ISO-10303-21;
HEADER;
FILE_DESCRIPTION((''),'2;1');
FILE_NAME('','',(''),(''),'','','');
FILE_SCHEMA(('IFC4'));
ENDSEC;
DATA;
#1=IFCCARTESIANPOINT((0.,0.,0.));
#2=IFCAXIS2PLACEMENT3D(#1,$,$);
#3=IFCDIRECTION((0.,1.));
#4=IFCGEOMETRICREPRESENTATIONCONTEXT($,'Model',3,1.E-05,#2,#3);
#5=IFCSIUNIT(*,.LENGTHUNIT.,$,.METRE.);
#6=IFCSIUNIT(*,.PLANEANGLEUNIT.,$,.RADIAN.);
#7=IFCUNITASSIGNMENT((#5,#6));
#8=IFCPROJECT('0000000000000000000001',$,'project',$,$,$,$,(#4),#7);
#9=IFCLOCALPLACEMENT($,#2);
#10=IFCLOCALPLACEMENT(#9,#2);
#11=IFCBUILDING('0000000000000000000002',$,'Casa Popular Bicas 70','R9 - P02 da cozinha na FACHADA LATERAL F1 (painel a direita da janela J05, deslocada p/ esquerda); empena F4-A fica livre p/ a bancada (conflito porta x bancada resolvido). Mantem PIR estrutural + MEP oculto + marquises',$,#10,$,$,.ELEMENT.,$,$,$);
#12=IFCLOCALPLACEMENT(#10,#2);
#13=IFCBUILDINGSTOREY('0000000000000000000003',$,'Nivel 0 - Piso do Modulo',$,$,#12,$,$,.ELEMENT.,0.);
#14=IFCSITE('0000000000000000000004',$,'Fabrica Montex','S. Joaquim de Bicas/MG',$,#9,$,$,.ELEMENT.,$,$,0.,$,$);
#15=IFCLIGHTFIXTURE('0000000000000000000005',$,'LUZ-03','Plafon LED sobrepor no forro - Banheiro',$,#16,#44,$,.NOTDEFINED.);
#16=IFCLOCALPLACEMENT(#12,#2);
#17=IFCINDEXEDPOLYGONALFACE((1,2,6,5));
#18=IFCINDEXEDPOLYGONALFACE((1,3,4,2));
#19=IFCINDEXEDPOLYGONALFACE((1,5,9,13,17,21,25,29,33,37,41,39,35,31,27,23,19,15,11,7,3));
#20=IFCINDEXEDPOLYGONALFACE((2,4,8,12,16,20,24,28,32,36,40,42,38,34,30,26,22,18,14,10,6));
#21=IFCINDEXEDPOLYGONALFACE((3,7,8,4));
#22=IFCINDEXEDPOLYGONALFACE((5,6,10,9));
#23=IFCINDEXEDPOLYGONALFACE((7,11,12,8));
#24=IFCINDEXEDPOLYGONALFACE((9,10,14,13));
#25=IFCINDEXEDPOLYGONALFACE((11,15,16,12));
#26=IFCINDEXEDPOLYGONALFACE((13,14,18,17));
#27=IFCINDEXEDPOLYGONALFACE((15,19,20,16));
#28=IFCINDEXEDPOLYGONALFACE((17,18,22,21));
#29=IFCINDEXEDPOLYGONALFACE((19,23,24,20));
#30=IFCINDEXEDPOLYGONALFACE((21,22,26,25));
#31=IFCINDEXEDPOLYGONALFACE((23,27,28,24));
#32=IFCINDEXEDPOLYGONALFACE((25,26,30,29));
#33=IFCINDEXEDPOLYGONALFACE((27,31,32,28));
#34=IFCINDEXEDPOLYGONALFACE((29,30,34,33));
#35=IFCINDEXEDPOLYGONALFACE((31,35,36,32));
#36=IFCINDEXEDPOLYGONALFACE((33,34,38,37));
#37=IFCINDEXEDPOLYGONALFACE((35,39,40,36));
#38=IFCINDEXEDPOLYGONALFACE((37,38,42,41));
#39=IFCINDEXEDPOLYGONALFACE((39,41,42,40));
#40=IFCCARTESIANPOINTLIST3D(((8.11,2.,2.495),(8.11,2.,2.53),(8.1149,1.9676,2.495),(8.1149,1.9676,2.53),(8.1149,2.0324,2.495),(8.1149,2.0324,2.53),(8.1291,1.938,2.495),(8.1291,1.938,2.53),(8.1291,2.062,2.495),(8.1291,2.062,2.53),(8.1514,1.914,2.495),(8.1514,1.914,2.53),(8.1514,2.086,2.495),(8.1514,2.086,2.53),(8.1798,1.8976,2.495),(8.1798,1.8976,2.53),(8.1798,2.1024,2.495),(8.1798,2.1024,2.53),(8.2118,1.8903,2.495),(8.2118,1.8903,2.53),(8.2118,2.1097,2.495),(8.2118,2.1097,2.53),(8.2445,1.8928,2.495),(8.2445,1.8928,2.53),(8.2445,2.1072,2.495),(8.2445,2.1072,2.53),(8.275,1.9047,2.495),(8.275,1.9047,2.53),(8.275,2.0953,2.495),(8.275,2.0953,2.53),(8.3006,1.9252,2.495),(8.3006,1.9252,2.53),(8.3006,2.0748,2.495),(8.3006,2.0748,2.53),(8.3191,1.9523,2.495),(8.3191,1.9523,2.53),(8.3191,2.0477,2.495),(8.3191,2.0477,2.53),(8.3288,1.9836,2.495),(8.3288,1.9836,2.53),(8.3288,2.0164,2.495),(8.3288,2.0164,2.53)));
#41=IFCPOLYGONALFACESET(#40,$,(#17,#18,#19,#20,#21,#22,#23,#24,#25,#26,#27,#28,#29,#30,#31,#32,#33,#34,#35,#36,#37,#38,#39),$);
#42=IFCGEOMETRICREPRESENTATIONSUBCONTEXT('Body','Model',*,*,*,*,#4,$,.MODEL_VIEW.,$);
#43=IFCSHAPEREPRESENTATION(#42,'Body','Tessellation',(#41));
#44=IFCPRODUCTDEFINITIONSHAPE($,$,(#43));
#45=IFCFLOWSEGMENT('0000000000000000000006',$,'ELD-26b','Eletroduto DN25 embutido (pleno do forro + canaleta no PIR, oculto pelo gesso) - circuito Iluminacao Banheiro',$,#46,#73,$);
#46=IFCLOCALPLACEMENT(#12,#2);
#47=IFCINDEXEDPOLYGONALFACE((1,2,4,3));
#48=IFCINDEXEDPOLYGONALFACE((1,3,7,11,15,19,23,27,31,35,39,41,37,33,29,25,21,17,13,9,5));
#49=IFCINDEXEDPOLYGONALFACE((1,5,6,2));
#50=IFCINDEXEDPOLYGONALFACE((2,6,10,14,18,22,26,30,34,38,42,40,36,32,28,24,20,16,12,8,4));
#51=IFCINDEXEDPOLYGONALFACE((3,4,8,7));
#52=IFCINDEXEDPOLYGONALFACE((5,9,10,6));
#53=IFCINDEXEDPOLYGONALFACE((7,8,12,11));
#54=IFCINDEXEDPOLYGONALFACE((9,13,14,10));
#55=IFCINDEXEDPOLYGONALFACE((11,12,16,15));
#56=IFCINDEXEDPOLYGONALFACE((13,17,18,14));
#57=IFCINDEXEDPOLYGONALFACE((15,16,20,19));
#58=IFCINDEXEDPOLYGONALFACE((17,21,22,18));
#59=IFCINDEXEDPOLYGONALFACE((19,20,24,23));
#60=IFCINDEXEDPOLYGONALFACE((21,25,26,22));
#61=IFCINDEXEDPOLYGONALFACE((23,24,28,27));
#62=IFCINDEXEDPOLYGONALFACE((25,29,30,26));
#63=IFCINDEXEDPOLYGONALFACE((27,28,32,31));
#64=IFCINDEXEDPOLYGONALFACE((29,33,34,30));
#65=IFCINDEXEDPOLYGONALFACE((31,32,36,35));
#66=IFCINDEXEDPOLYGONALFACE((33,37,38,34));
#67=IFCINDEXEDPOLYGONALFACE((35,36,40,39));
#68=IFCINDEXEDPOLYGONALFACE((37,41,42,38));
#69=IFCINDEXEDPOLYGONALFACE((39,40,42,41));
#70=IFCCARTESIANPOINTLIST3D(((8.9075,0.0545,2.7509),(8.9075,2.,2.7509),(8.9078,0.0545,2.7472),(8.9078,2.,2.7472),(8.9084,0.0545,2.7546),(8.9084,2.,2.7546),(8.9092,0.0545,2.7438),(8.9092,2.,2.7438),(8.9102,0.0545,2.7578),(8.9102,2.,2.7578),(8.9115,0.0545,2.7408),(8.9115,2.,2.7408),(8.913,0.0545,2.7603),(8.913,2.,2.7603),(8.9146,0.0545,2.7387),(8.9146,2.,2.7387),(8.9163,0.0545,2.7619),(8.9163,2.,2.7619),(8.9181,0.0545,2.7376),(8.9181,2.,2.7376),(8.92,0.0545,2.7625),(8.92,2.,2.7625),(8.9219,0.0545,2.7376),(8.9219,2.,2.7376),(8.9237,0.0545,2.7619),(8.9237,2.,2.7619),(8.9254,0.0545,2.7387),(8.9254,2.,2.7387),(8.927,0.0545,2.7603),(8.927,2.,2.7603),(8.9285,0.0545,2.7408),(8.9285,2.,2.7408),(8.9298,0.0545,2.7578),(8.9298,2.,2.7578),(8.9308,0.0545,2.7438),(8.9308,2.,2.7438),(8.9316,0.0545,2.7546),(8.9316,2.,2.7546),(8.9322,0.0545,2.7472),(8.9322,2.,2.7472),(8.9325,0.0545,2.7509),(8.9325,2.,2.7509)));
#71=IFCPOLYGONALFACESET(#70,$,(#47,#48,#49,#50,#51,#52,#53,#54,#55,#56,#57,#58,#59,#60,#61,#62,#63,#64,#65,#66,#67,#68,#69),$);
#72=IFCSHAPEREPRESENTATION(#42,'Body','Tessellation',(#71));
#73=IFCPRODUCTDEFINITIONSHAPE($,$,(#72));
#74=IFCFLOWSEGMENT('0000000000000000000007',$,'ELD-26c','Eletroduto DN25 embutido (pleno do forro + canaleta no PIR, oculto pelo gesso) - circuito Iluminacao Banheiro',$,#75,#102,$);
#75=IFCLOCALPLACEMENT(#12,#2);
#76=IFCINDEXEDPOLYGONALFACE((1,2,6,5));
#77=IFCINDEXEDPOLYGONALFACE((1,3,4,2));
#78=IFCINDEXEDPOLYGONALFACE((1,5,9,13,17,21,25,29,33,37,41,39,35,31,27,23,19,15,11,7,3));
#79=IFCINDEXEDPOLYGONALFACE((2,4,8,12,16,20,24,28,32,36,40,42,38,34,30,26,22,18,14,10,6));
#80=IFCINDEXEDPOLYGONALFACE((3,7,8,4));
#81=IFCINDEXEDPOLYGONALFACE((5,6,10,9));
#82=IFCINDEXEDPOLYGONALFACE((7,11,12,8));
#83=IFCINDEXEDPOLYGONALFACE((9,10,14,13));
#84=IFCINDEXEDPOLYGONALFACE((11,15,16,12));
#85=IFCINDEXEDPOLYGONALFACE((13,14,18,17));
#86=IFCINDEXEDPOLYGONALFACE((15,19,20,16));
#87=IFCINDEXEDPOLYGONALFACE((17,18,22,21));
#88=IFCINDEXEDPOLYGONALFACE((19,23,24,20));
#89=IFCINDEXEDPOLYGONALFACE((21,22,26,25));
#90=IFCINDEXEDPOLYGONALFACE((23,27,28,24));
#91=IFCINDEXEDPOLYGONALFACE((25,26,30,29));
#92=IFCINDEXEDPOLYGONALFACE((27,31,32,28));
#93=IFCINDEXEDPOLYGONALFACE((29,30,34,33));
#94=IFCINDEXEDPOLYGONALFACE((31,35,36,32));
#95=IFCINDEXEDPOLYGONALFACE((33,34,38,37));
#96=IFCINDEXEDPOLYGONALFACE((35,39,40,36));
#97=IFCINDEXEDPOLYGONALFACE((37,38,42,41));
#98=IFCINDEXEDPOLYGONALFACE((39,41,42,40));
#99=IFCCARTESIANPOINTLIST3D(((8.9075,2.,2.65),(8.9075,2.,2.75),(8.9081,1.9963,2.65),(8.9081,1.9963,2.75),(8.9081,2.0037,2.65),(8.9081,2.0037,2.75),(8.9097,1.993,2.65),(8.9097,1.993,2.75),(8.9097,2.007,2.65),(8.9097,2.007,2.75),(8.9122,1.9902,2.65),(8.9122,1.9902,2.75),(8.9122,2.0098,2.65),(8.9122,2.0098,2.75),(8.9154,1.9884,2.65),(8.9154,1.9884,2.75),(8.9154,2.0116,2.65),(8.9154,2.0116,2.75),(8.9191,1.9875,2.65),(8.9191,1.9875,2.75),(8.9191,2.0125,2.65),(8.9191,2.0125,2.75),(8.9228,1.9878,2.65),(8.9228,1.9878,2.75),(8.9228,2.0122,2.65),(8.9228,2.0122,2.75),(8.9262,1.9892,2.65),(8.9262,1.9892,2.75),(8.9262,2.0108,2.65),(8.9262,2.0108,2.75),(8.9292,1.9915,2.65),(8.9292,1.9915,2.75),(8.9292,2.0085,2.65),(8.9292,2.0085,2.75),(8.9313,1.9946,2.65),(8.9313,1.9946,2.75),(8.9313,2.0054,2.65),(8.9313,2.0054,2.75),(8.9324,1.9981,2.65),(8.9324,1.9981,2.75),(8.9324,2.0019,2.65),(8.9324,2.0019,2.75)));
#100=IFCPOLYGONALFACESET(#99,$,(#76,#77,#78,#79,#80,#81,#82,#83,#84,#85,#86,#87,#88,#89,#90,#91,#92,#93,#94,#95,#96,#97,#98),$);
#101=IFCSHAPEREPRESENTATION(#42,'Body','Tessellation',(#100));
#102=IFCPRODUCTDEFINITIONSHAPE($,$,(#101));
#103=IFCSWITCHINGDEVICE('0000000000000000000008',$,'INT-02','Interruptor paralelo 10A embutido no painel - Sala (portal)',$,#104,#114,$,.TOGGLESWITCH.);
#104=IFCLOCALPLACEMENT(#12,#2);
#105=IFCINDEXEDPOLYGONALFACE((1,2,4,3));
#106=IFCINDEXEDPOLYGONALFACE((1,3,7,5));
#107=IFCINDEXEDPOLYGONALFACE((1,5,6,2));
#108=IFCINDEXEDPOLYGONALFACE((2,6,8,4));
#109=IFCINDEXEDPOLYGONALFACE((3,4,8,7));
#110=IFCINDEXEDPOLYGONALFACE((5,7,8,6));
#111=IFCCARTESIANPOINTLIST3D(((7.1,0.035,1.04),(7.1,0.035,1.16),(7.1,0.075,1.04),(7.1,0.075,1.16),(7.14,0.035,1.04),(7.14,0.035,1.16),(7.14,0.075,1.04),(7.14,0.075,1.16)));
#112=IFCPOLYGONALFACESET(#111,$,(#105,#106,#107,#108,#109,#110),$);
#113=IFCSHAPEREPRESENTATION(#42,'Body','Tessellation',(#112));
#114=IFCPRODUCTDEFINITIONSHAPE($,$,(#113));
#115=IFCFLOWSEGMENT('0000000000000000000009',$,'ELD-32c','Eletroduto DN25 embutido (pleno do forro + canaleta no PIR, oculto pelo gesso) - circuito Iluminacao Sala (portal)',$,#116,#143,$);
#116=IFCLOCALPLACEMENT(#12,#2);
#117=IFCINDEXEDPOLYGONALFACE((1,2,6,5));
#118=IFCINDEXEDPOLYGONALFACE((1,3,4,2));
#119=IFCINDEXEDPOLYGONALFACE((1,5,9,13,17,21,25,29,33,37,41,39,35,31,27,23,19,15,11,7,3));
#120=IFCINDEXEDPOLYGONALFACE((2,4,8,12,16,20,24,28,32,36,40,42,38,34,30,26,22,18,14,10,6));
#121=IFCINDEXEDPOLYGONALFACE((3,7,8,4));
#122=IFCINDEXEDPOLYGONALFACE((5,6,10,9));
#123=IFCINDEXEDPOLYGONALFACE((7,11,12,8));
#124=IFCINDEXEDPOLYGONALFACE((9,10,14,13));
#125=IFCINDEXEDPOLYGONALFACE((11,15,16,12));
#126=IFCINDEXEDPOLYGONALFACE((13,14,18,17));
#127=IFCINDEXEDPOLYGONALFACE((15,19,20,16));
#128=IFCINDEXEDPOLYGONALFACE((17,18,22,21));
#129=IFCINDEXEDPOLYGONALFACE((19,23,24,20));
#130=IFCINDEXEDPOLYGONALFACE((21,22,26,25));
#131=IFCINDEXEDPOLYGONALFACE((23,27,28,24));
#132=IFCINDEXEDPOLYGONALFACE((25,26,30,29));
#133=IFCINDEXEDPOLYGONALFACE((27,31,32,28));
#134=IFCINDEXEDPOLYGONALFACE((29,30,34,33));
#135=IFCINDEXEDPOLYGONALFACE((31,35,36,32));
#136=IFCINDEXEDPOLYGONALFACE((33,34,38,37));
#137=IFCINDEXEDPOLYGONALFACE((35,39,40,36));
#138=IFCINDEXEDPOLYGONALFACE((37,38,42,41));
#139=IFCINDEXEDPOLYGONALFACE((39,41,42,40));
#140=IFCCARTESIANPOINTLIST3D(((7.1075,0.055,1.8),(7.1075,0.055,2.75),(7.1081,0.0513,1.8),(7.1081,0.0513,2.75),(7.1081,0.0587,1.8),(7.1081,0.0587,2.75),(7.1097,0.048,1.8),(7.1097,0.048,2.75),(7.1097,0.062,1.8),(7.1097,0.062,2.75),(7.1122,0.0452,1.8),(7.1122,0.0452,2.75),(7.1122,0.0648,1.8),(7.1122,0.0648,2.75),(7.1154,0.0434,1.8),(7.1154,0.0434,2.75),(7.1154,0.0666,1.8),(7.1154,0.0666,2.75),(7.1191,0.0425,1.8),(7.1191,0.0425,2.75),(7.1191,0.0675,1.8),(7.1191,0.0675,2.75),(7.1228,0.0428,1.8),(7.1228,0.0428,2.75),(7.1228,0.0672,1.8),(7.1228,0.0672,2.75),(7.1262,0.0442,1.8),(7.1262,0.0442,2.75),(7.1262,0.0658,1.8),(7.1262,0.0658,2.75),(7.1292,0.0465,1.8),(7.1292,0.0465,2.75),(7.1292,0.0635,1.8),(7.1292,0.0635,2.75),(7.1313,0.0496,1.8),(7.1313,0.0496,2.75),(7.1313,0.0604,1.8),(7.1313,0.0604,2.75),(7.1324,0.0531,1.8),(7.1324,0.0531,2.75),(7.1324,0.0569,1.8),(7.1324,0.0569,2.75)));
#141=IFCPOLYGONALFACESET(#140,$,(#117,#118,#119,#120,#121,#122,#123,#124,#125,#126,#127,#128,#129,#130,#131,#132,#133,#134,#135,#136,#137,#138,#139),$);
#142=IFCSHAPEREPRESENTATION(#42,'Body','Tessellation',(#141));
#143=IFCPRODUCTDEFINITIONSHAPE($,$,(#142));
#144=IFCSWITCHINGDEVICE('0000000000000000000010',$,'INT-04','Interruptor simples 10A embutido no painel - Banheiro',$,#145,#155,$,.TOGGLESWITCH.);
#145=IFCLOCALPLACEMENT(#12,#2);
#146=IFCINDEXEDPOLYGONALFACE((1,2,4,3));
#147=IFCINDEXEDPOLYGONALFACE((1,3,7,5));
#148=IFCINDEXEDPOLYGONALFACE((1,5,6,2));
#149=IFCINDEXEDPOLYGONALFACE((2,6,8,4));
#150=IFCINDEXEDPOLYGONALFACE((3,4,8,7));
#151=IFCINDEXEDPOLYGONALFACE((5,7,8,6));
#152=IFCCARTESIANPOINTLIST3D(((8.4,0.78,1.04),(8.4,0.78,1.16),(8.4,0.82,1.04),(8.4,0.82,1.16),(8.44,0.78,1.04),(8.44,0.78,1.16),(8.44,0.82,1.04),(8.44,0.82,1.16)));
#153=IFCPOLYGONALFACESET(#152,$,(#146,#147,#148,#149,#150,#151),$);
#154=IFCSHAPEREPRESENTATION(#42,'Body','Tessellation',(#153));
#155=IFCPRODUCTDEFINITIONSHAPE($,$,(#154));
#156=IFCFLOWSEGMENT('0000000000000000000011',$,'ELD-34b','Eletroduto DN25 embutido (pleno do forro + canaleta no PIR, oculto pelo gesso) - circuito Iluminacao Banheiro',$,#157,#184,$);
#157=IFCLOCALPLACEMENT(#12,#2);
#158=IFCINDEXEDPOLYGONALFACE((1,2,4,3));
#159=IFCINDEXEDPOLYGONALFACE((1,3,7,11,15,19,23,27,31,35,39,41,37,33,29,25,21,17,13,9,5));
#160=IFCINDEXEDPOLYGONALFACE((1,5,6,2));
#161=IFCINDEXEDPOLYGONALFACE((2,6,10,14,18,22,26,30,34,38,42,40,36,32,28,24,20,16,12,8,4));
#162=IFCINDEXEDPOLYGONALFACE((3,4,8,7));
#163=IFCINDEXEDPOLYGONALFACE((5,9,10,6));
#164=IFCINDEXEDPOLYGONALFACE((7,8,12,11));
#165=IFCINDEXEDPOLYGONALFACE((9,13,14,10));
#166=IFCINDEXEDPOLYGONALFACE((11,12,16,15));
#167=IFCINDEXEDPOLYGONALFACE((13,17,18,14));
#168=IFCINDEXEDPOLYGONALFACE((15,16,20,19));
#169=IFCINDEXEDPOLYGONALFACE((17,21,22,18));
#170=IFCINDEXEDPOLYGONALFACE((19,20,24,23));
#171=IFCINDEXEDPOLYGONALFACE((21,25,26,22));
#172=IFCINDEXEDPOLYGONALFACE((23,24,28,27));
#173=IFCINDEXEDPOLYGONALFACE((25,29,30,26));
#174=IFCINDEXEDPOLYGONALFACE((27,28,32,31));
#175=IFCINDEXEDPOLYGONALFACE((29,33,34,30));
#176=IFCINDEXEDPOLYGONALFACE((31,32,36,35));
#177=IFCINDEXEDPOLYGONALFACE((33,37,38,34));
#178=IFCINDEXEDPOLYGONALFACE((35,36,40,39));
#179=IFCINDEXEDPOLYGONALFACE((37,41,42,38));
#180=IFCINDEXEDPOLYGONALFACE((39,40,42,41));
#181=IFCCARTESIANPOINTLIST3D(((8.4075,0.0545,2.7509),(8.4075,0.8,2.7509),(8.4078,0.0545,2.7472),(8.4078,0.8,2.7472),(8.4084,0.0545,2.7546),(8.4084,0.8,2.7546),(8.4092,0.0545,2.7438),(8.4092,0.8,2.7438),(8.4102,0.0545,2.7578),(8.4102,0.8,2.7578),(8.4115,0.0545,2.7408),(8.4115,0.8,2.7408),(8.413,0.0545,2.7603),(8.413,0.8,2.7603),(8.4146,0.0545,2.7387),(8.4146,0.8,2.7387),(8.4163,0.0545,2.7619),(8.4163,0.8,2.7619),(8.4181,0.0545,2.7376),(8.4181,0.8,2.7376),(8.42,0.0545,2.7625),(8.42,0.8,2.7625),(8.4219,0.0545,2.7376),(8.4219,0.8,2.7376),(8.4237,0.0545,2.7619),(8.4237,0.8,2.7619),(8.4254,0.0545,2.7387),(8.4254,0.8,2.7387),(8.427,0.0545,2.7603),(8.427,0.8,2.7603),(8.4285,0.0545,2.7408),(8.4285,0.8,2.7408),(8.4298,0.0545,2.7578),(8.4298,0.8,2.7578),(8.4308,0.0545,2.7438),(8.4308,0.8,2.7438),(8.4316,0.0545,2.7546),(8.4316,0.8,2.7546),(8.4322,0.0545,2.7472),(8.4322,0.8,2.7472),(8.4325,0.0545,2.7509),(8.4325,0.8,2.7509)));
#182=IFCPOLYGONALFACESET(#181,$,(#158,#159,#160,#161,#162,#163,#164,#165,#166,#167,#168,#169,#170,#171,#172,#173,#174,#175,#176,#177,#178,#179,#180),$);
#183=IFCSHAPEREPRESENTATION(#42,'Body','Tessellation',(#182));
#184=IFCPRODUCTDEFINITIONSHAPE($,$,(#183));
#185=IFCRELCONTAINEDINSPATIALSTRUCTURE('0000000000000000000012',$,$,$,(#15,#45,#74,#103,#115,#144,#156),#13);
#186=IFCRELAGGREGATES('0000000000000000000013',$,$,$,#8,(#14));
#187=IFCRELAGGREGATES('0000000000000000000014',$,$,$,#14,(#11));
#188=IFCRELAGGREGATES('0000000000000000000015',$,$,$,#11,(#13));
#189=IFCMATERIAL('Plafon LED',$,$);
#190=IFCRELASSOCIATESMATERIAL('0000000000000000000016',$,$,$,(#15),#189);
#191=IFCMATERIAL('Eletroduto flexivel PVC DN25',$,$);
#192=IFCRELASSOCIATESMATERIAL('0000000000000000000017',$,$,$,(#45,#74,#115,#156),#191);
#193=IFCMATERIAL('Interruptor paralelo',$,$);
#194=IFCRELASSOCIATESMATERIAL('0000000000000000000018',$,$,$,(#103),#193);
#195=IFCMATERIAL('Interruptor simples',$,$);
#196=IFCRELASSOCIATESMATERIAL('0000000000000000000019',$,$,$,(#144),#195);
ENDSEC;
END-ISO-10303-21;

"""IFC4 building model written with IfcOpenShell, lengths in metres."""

from ifc_helpers import new_model, si_unit, direction, frame, frame_2d, origin, origin_2d, place, context, subcontext, project, spatial, rectangle, circle, extrude, material, element, save


model = new_model("IFC4")

# Units and contexts
model_context = context("Model", 3, precision=1e-05, world=origin(), true_north=direction((0.0, 1.0)))
body_context = subcontext(model_context, "Body", "Model", "MODEL_VIEW")
ifc_project = project(units=[si_unit("LENGTHUNIT", "METRE"), si_unit("PLANEANGLEUNIT", "RADIAN")], contexts=[model_context])

# Site, building, storey
site_placement = place(None, origin())
site = spatial("IfcSite", under=ifc_project, at=site_placement, Name="Fabrica Montex", Description="S. Joaquim de Bicas/MG", CompositionType="ELEMENT", RefElevation=0.0)
building_placement = place(site_placement, origin())
building = spatial("IfcBuilding", under=site, at=building_placement, Name="Casa Popular Bicas 70", Description="R9 - P02 da cozinha na FACHADA LATERAL F1 (painel a direita da janela J05, deslocada p/ esquerda); empena F4-A fica livre p/ a bancada (conflito porta x bancada resolvido). Mantem PIR estrutural + MEP oculto + marquises", CompositionType="ELEMENT")
storey_placement = place(building_placement, origin())
storey = spatial("IfcBuildingStorey", under=building, at=storey_placement, Name="Nivel 0 - Piso do Modulo", CompositionType="ELEMENT", Elevation=0.0)

# Shared definitions
ifc_material_1 = material(Name="Eletroduto flexivel PVC DN25")

# Light fixture
ifc_material_2 = material(Name="Plafon LED")
light_fixture_placement = place(None, frame((8.22, 2.0, 2.495), z_axis=(0.0, 0.0, 1.0), x_axis=(-1.0, 0.0, 0.0)))
element("IfcLightFixture", 1, at=light_fixture_placement, inside=storey, material=ifc_material_2, Name="LUZ-03", Description="Plafon LED sobrepor no forro - Banheiro", PredefinedType="NOTDEFINED", context=body_context, shape_type="SweptSolid", body=[
    extrude(circle(Radius=0.11, at=origin_2d()), origin(), (0.0, 0.0, 1.0), 0.035),
])

# Flow segments
flow_segment_1_placement = place(None, frame((8.92, 0.0545, 2.75), z_axis=(0.0, 1.0, 0.0), x_axis=(0.0, 0.0, 1.0)))
element("IfcFlowSegment", 2, at=flow_segment_1_placement, inside=storey, material=ifc_material_1, Name="ELD-26b", Description="Eletroduto DN25 embutido (pleno do forro + canaleta no PIR, oculto pelo gesso) - circuito Iluminacao Banheiro", context=body_context, shape_type="SweptSolid", body=[
    extrude(circle(Radius=0.0125, at=origin_2d()), origin(), (0.0, 0.0, 1.0), 1.9455),
])
flow_segment_2_placement = place(None, frame((8.92, 2.0, 2.75), z_axis=(0.0, 0.0, -1.0), x_axis=(-1.0, 0.0, 0.0)))
element("IfcFlowSegment", 3, at=flow_segment_2_placement, inside=storey, material=ifc_material_1, Name="ELD-26c", Description="Eletroduto DN25 embutido (pleno do forro + canaleta no PIR, oculto pelo gesso) - circuito Iluminacao Banheiro", context=body_context, shape_type="SweptSolid", body=[
    extrude(circle(Radius=0.0125, at=origin_2d()), origin(), (0.0, 0.0, 1.0), 0.1),
])

# Switching device
ifc_material_3 = material(Name="Interruptor paralelo")
switching_device_1_placement = place(None, frame((7.14, 0.075, 1.04), z_axis=(0.0, 0.0, 1.0), x_axis=(-1.0, 0.0, 0.0)))
element("IfcSwitchingDevice", 4, at=switching_device_1_placement, inside=storey, material=ifc_material_3, Name="INT-02", Description="Interruptor paralelo 10A embutido no painel - Sala (portal)", PredefinedType="TOGGLESWITCH", context=body_context, shape_type="SweptSolid", body=[
    extrude(rectangle(XDim=0.04, YDim=0.04, at=frame_2d((0.02, 0.02))), origin(), (0.0, 0.0, 1.0), 0.12),
])

# Flow segment
flow_segment_3_placement = place(None, frame((7.12, 0.055, 2.75), z_axis=(0.0, 0.0, -1.0), x_axis=(-1.0, 0.0, 0.0)))
element("IfcFlowSegment", 5, at=flow_segment_3_placement, inside=storey, material=ifc_material_1, Name="ELD-32c", Description="Eletroduto DN25 embutido (pleno do forro + canaleta no PIR, oculto pelo gesso) - circuito Iluminacao Sala (portal)", context=body_context, shape_type="SweptSolid", body=[
    extrude(circle(Radius=0.0125, at=origin_2d()), origin(), (0.0, 0.0, 1.0), 0.95),
])

# Switching device
ifc_material_4 = material(Name="Interruptor simples")
switching_device_2_placement = place(None, frame((8.44, 0.82, 1.04), z_axis=(0.0, 0.0, 1.0), x_axis=(-1.0, 0.0, 0.0)))
element("IfcSwitchingDevice", 6, at=switching_device_2_placement, inside=storey, material=ifc_material_4, Name="INT-04", Description="Interruptor simples 10A embutido no painel - Banheiro", PredefinedType="TOGGLESWITCH", context=body_context, shape_type="SweptSolid", body=[
    extrude(rectangle(XDim=0.04, YDim=0.04, at=frame_2d((0.02, 0.02))), origin(), (0.0, 0.0, 1.0), 0.12),
])

# Flow segment
flow_segment_4_placement = place(None, frame((8.42, 0.0545, 2.75), z_axis=(0.0, 1.0, 0.0), x_axis=(0.0, 0.0, 1.0)))
element("IfcFlowSegment", 7, at=flow_segment_4_placement, inside=storey, material=ifc_material_1, Name="ELD-34b", Description="Eletroduto DN25 embutido (pleno do forro + canaleta no PIR, oculto pelo gesso) - circuito Iluminacao Banheiro", context=body_context, shape_type="SweptSolid", body=[
    extrude(circle(Radius=0.0125, at=origin_2d()), origin(), (0.0, 0.0, 1.0), 0.7455),
])

save(model, "model.ifc")
